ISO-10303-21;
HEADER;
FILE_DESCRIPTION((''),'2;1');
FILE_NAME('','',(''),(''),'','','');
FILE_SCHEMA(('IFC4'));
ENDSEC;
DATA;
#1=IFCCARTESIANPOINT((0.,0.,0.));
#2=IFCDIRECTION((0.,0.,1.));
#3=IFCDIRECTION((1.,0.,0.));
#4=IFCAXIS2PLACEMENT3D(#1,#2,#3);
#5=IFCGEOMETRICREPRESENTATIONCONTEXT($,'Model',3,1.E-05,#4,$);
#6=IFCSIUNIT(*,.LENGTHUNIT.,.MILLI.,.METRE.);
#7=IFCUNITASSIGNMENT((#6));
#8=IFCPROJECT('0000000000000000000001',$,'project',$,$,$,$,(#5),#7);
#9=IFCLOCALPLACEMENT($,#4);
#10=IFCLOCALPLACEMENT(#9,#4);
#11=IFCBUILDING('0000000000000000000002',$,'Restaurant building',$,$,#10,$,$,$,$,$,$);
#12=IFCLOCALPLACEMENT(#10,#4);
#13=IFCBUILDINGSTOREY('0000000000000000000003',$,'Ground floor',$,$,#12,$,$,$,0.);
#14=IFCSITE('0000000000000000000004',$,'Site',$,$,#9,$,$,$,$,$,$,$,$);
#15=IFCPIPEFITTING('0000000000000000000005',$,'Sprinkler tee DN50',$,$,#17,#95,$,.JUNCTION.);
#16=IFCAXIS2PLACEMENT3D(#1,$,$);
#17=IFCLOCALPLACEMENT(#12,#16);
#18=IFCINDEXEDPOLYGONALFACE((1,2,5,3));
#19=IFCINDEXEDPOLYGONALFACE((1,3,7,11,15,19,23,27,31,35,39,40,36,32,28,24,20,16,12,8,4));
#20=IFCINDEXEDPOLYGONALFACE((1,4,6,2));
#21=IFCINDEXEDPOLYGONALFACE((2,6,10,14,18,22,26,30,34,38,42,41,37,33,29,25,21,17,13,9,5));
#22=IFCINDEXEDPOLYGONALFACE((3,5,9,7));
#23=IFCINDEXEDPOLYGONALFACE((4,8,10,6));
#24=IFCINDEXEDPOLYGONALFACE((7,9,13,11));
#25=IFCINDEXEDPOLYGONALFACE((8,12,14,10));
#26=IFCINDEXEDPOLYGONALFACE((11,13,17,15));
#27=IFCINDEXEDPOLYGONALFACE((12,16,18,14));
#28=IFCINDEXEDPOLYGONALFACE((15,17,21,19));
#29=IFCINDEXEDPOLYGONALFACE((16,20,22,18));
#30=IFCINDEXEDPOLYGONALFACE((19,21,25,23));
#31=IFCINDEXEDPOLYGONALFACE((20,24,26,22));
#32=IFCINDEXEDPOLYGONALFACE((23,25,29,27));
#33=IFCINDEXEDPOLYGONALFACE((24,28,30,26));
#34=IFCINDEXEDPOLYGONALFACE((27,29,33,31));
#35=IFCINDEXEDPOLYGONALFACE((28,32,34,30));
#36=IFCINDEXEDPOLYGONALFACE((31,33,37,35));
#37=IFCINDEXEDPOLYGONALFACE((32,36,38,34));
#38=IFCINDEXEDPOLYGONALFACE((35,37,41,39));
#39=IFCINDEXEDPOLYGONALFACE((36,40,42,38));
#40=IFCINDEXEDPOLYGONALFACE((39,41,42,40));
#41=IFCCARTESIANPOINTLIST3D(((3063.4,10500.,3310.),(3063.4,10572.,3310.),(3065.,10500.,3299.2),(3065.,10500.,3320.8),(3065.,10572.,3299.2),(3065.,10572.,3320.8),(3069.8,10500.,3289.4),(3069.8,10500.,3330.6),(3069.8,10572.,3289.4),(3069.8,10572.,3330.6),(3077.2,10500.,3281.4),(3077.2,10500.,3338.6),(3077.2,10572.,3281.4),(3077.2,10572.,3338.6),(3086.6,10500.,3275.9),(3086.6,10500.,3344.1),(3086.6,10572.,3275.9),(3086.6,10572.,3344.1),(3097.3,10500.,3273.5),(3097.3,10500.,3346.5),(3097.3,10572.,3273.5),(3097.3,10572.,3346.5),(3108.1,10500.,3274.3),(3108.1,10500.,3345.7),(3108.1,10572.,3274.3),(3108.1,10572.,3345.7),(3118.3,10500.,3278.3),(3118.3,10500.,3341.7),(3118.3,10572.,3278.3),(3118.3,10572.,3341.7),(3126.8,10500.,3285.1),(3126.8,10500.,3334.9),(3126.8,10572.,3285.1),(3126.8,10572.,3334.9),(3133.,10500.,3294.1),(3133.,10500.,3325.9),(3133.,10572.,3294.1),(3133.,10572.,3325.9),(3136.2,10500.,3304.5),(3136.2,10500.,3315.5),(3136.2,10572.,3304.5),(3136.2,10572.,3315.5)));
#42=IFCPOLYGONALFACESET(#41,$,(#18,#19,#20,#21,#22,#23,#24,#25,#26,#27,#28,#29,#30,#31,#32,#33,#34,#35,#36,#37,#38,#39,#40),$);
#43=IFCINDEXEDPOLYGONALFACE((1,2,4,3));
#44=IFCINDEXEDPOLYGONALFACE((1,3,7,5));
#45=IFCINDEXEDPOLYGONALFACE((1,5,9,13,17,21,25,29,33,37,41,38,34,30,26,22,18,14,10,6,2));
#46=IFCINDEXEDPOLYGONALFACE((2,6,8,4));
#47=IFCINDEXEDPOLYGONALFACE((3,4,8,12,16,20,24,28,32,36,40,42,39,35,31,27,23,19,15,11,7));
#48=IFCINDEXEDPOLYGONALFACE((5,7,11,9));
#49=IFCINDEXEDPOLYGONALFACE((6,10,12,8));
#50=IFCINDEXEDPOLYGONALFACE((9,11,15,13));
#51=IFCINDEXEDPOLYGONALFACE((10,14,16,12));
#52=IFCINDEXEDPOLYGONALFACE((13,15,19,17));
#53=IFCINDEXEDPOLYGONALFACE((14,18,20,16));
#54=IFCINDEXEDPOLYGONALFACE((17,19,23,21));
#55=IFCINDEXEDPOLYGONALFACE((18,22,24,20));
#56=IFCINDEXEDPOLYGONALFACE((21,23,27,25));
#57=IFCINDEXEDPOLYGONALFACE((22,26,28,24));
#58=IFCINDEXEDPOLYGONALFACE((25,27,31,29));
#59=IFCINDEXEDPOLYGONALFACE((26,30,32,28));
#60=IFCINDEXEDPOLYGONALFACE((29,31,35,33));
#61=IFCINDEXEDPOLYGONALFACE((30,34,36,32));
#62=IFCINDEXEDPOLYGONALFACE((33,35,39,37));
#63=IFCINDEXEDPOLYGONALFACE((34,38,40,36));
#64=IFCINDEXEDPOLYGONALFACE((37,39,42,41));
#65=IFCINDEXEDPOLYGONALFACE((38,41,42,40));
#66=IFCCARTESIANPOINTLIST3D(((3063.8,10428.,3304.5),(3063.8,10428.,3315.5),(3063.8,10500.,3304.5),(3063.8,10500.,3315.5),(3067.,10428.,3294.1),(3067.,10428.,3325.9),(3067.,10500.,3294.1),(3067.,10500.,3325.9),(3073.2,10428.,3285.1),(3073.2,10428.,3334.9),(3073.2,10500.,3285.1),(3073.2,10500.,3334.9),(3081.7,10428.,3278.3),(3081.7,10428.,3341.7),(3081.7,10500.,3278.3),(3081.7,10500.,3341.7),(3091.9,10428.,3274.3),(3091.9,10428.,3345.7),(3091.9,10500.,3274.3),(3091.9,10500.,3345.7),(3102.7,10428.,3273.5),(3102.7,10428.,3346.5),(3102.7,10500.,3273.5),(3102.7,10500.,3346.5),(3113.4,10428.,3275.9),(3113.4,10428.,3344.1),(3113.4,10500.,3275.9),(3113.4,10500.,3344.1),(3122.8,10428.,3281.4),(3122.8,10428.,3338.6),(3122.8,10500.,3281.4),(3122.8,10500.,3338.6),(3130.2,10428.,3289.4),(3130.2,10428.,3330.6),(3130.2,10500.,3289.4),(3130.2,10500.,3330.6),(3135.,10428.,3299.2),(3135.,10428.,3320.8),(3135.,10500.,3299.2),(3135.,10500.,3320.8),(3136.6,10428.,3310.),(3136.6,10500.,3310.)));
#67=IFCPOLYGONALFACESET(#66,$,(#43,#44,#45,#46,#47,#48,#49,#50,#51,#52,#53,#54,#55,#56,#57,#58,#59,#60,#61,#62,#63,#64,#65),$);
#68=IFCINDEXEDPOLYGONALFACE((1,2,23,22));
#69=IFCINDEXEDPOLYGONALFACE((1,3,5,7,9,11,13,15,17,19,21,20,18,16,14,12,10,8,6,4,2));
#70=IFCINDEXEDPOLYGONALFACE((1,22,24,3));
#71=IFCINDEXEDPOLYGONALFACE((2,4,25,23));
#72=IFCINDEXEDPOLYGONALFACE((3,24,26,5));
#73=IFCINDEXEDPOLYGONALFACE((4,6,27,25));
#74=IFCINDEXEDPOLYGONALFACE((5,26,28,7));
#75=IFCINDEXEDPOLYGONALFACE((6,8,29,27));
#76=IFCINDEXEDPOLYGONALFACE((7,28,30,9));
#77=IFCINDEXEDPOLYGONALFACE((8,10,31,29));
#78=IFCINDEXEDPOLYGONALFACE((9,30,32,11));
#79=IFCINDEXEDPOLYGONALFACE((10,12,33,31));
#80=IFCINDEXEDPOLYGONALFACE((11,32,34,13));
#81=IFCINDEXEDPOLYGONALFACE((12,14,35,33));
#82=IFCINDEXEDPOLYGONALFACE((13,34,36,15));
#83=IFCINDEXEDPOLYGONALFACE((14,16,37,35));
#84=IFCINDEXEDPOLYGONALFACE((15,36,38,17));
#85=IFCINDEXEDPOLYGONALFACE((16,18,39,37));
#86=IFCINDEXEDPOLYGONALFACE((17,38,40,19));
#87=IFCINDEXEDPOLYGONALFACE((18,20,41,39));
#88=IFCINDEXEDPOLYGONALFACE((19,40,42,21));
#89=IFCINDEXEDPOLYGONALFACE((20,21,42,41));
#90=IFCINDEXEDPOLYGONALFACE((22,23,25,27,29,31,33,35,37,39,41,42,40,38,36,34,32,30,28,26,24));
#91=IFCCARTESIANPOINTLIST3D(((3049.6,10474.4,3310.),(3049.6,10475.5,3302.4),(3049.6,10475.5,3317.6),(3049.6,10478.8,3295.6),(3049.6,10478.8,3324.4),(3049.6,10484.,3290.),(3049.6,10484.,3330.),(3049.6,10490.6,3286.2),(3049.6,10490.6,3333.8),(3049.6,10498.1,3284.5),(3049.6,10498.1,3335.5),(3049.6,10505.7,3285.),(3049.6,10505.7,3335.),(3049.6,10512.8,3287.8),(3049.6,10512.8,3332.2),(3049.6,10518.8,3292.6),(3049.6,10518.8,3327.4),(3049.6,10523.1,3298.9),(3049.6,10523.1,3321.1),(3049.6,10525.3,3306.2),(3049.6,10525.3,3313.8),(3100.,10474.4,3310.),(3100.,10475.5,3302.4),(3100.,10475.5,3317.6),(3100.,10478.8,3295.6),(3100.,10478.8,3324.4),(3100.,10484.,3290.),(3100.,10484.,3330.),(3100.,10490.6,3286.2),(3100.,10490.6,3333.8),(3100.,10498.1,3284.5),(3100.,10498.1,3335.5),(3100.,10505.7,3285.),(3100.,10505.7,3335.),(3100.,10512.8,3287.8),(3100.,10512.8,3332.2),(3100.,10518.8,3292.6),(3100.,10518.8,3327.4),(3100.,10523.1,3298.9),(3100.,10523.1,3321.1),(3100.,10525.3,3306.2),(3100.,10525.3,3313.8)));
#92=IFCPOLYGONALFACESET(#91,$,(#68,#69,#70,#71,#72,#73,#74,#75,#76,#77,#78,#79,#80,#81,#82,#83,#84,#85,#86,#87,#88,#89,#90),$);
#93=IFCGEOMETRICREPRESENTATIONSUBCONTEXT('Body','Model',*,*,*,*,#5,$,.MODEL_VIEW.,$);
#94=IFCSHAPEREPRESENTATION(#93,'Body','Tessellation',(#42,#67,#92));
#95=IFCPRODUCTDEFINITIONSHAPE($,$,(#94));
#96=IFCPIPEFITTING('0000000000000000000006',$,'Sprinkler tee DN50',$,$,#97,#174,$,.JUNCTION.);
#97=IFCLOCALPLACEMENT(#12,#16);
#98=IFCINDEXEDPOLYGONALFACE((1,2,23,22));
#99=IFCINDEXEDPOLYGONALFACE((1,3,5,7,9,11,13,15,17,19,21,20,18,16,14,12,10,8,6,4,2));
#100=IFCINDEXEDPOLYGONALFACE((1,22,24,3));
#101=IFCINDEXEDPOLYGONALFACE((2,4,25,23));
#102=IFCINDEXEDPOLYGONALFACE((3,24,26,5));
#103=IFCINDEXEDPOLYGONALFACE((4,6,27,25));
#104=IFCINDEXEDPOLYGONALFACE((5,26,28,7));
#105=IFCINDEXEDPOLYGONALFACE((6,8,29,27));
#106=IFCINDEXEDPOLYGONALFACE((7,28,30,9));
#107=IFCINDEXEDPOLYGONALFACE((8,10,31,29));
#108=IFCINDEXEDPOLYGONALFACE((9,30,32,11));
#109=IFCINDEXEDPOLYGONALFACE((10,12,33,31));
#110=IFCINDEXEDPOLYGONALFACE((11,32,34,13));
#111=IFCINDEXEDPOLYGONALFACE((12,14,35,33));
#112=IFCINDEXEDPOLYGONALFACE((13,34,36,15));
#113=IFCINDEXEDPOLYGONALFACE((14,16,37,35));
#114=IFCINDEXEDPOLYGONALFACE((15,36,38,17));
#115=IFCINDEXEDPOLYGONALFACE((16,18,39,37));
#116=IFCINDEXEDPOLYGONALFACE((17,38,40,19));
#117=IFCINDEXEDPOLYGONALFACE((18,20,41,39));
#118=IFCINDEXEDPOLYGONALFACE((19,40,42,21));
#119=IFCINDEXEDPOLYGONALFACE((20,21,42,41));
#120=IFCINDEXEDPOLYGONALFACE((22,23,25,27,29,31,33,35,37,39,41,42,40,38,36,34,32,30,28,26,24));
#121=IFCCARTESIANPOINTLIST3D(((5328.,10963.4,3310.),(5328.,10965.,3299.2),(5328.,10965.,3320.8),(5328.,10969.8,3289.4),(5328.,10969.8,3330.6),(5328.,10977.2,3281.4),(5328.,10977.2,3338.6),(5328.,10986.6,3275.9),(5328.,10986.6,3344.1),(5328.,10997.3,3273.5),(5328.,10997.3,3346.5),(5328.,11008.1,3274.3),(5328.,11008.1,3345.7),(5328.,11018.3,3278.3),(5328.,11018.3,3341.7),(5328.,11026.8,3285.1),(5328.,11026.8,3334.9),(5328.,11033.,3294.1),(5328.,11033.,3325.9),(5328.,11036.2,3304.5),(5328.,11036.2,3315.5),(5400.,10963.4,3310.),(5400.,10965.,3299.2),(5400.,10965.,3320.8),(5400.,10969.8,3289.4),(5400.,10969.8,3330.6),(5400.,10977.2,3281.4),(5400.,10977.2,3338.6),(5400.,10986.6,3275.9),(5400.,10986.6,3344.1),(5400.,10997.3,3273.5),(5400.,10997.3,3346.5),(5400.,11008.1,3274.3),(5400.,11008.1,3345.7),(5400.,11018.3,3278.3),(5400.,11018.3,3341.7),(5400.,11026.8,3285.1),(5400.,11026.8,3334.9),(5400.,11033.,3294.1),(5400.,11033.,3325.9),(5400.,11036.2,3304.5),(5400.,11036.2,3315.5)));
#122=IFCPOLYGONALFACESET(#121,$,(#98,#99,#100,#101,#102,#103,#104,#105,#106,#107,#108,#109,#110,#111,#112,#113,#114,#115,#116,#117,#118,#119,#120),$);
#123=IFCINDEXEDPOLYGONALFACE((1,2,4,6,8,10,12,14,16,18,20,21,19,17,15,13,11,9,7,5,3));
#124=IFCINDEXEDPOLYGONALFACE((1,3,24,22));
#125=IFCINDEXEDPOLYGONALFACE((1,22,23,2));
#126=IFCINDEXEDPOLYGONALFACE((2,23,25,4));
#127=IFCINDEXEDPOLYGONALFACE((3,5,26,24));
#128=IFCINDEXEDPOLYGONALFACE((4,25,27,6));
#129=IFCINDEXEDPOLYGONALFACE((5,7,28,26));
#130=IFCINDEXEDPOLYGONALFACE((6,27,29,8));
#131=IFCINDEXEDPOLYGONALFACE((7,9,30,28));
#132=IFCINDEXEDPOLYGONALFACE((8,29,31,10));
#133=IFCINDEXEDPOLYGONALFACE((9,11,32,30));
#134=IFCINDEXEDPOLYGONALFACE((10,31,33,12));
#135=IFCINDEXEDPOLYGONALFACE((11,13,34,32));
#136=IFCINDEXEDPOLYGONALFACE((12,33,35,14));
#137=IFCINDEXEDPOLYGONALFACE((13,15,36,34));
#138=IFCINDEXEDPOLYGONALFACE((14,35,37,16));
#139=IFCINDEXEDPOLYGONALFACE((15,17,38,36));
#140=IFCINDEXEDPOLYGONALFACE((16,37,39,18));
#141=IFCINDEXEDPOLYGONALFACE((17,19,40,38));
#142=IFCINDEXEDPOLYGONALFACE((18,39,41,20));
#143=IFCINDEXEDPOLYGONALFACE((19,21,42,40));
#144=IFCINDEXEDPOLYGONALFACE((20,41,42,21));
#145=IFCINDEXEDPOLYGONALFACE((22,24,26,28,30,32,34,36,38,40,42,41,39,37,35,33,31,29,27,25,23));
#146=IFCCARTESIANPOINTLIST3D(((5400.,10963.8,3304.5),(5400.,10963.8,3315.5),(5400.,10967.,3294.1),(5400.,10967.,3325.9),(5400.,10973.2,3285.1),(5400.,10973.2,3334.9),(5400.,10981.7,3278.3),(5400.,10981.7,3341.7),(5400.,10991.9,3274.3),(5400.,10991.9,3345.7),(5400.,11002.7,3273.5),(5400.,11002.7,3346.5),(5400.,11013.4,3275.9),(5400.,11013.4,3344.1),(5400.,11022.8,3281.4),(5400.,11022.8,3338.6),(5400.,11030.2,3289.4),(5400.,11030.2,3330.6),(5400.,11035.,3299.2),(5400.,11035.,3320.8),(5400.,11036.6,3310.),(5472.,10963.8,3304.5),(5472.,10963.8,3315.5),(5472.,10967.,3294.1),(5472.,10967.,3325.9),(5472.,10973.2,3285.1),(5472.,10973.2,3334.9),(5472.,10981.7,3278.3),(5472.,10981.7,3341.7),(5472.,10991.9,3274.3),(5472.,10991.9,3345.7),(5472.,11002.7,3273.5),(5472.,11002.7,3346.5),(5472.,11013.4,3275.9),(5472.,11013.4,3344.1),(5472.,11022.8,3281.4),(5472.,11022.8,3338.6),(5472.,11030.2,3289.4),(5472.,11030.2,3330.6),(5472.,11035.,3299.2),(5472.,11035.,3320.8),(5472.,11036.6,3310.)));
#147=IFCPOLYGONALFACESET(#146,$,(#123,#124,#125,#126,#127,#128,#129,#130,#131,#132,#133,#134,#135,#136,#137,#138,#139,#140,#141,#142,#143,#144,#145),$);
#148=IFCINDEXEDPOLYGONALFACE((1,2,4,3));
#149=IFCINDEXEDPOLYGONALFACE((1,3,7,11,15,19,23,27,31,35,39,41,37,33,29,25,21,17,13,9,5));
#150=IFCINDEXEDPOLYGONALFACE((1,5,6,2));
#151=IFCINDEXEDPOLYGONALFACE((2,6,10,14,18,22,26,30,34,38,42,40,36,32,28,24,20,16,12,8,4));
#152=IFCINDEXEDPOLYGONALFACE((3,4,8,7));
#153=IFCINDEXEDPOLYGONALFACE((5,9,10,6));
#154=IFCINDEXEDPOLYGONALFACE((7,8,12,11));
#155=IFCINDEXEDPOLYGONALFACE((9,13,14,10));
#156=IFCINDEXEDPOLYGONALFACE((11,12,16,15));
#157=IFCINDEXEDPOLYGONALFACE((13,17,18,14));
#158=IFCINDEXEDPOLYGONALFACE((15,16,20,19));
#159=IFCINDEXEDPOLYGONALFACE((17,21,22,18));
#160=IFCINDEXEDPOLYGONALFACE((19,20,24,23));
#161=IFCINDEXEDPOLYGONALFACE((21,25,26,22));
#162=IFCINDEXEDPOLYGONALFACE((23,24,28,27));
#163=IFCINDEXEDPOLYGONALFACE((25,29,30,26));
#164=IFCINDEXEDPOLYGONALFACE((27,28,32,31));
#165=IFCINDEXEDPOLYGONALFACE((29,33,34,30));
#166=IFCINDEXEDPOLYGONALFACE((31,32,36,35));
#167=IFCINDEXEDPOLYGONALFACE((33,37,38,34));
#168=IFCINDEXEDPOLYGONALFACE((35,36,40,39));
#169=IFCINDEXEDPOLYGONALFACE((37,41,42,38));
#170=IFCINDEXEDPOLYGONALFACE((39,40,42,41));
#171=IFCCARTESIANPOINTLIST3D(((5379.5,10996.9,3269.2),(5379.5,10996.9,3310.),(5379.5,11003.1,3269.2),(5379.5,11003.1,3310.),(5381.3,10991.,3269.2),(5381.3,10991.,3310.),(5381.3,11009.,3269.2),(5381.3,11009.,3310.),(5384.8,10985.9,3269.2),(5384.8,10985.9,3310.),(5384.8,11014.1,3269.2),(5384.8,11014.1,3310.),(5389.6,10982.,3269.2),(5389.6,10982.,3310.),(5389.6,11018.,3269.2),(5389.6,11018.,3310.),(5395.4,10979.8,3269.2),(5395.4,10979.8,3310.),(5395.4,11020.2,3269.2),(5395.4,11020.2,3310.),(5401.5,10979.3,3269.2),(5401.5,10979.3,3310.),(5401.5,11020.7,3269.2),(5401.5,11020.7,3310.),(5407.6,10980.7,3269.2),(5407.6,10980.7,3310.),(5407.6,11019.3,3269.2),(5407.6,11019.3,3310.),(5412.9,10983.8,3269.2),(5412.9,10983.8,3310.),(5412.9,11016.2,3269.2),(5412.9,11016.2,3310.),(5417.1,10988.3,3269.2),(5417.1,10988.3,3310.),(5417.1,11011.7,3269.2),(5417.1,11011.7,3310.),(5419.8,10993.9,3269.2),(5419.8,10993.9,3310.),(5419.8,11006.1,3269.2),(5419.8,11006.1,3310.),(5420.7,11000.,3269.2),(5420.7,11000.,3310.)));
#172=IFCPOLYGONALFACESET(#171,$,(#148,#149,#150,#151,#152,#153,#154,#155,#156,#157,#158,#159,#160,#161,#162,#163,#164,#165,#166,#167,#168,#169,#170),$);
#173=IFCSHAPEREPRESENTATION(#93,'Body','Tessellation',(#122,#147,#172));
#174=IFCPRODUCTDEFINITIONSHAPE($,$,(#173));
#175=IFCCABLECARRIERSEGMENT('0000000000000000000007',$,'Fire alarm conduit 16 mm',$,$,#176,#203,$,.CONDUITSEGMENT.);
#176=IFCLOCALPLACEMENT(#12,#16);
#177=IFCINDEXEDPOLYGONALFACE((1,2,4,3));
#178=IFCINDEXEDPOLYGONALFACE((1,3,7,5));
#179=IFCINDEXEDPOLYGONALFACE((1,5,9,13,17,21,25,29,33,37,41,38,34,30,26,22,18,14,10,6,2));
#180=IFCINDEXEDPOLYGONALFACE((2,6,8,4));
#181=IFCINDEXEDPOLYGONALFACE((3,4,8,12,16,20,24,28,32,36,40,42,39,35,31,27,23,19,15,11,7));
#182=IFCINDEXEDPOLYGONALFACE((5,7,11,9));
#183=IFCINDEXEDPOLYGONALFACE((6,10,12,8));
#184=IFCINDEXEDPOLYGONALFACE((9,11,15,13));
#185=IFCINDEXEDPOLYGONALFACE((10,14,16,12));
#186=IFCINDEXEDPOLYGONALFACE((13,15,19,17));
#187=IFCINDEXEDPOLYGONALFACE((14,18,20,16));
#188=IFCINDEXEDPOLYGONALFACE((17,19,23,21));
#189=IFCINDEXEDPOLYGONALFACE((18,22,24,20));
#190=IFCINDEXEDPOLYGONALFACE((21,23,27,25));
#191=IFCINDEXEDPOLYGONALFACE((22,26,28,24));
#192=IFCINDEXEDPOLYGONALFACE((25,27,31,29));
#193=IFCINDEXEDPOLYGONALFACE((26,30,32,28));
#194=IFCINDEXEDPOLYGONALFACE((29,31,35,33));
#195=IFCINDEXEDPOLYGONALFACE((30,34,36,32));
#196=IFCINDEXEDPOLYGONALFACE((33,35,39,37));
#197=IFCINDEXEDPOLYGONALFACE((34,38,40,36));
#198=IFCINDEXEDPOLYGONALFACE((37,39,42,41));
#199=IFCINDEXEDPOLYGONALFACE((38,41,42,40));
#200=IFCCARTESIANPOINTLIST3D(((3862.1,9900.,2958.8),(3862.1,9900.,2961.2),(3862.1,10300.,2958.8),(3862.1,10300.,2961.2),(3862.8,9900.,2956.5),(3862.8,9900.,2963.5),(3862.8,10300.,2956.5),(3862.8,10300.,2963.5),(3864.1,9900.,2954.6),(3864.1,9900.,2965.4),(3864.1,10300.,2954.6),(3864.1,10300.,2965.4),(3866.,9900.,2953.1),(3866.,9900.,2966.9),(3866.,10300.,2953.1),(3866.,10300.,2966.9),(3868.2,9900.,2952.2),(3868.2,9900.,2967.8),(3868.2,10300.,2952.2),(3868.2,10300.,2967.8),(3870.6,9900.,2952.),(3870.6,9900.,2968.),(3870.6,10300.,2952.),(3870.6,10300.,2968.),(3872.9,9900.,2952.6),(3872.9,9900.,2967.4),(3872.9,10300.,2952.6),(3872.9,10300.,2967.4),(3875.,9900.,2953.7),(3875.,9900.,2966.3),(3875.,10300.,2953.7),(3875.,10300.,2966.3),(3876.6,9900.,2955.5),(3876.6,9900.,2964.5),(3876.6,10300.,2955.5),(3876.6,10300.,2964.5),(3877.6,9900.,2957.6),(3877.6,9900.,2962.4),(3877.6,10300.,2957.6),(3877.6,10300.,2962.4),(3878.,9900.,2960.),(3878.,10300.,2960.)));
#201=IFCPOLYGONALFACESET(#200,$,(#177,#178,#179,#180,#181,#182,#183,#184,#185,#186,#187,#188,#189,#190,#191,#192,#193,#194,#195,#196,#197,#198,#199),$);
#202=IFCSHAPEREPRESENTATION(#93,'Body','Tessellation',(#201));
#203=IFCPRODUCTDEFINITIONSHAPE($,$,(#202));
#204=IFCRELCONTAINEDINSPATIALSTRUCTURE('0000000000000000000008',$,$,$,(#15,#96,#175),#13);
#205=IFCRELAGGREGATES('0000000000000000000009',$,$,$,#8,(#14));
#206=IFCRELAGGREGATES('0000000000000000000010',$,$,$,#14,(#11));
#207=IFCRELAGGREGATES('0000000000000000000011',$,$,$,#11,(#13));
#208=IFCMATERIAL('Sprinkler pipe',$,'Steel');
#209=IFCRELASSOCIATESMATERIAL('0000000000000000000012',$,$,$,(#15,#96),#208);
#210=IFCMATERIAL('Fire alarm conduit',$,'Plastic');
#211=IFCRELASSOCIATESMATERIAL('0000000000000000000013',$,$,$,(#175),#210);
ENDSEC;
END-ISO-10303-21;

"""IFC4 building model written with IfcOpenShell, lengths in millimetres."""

from ifc_helpers import new_model, si_unit, frame, origin_with_axes, origin_2d, place, context, subcontext, project, spatial, circle, extrude, material, element, save


model = new_model("IFC4")

# Units and contexts
model_context = context("Model", 3, precision=1e-05, world=origin_with_axes())
body_context = subcontext(model_context, "Body", "Model", "MODEL_VIEW")
ifc_project = project(units=[si_unit("LENGTHUNIT", "METRE", prefix="MILLI")], contexts=[model_context])

# Site, building, storey
site_placement = place(None, origin_with_axes())
site = spatial("IfcSite", under=ifc_project, at=site_placement, Name="Site")
building_placement = place(site_placement, origin_with_axes())
building = spatial("IfcBuilding", under=site, at=building_placement, Name="Restaurant building")
storey_placement = place(building_placement, origin_with_axes())
storey = spatial("IfcBuildingStorey", under=building, at=storey_placement, Name="Ground floor", Elevation=0.0)

# Shared definitions
ifc_material_1 = material(Name="Sprinkler pipe", Category="Steel")

# Pipe fittings
pipe_fitting_1_placement = place(storey_placement, frame((3100.0, 10500.0, 3310.0)))
element("IfcPipeFitting", 1, at=pipe_fitting_1_placement, inside=storey, material=ifc_material_1, Name="Sprinkler tee DN50", PredefinedType="JUNCTION", context=body_context, shape_type="SweptSolid", body=[
    extrude(circle(Radius=36.6, at=origin_2d()), frame((0.0, 0.0, 0.0), z_axis=(0.0, 1.0, 0.0), x_axis=(-1.0, 0.0, 0.0)), (0.0, 0.0, 1.0), 72.0),
    extrude(circle(Radius=36.6, at=origin_2d()), frame((0.0, 0.0, 0.0), z_axis=(0.0, -1.0, 0.0), x_axis=(1.0, 0.0, 0.0)), (0.0, 0.0, 1.0), 72.0),
    extrude(circle(Radius=25.6, at=origin_2d()), frame((0.0, 0.0, 0.0), z_axis=(-1.0, 0.0, 0.0), x_axis=(0.0, -1.0, 0.0)), (0.0, 0.0, 1.0), 50.4),
])
pipe_fitting_2_placement = place(storey_placement, frame((5400.0, 11000.0, 3310.0)))
element("IfcPipeFitting", 2, at=pipe_fitting_2_placement, inside=storey, material=ifc_material_1, Name="Sprinkler tee DN50", PredefinedType="JUNCTION", context=body_context, shape_type="SweptSolid", body=[
    extrude(circle(Radius=36.6, at=origin_2d()), frame((0.0, 0.0, 0.0), z_axis=(-1.0, 0.0, 0.0), x_axis=(0.0, -1.0, 0.0)), (0.0, 0.0, 1.0), 72.0),
    extrude(circle(Radius=36.6, at=origin_2d()), frame((0.0, 0.0, 0.0), z_axis=(1.0, 0.0, 0.0), x_axis=(0.0, 1.0, 0.0)), (0.0, 0.0, 1.0), 72.0),
    extrude(circle(Radius=20.7, at=origin_2d()), frame((0.0, 0.0, 0.0), z_axis=(0.0, 0.0, -1.0), x_axis=(1.0, 0.0, 0.0)), (0.0, 0.0, 1.0), 40.8),
])

# Cable carrier segment
ifc_material_2 = material(Name="Fire alarm conduit", Category="Plastic")
cable_carrier_segment_1_placement = place(storey_placement, frame((3870.0, 10300.0, 2960.0)))
element("IfcCableCarrierSegment", 3, at=cable_carrier_segment_1_placement, inside=storey, material=ifc_material_2, Name="Fire alarm conduit 16 mm", PredefinedType="CONDUITSEGMENT", context=body_context, shape_type="SweptSolid", body=[
    extrude(circle(Radius=8.0, at=origin_2d()), frame((0.0, 0.0, 0.0), z_axis=(0.0, -1.0, 0.0), x_axis=(1.0, 0.0, 0.0)), (0.0, 0.0, 1.0), 400.0),
])

save(model, "model.ifc")
